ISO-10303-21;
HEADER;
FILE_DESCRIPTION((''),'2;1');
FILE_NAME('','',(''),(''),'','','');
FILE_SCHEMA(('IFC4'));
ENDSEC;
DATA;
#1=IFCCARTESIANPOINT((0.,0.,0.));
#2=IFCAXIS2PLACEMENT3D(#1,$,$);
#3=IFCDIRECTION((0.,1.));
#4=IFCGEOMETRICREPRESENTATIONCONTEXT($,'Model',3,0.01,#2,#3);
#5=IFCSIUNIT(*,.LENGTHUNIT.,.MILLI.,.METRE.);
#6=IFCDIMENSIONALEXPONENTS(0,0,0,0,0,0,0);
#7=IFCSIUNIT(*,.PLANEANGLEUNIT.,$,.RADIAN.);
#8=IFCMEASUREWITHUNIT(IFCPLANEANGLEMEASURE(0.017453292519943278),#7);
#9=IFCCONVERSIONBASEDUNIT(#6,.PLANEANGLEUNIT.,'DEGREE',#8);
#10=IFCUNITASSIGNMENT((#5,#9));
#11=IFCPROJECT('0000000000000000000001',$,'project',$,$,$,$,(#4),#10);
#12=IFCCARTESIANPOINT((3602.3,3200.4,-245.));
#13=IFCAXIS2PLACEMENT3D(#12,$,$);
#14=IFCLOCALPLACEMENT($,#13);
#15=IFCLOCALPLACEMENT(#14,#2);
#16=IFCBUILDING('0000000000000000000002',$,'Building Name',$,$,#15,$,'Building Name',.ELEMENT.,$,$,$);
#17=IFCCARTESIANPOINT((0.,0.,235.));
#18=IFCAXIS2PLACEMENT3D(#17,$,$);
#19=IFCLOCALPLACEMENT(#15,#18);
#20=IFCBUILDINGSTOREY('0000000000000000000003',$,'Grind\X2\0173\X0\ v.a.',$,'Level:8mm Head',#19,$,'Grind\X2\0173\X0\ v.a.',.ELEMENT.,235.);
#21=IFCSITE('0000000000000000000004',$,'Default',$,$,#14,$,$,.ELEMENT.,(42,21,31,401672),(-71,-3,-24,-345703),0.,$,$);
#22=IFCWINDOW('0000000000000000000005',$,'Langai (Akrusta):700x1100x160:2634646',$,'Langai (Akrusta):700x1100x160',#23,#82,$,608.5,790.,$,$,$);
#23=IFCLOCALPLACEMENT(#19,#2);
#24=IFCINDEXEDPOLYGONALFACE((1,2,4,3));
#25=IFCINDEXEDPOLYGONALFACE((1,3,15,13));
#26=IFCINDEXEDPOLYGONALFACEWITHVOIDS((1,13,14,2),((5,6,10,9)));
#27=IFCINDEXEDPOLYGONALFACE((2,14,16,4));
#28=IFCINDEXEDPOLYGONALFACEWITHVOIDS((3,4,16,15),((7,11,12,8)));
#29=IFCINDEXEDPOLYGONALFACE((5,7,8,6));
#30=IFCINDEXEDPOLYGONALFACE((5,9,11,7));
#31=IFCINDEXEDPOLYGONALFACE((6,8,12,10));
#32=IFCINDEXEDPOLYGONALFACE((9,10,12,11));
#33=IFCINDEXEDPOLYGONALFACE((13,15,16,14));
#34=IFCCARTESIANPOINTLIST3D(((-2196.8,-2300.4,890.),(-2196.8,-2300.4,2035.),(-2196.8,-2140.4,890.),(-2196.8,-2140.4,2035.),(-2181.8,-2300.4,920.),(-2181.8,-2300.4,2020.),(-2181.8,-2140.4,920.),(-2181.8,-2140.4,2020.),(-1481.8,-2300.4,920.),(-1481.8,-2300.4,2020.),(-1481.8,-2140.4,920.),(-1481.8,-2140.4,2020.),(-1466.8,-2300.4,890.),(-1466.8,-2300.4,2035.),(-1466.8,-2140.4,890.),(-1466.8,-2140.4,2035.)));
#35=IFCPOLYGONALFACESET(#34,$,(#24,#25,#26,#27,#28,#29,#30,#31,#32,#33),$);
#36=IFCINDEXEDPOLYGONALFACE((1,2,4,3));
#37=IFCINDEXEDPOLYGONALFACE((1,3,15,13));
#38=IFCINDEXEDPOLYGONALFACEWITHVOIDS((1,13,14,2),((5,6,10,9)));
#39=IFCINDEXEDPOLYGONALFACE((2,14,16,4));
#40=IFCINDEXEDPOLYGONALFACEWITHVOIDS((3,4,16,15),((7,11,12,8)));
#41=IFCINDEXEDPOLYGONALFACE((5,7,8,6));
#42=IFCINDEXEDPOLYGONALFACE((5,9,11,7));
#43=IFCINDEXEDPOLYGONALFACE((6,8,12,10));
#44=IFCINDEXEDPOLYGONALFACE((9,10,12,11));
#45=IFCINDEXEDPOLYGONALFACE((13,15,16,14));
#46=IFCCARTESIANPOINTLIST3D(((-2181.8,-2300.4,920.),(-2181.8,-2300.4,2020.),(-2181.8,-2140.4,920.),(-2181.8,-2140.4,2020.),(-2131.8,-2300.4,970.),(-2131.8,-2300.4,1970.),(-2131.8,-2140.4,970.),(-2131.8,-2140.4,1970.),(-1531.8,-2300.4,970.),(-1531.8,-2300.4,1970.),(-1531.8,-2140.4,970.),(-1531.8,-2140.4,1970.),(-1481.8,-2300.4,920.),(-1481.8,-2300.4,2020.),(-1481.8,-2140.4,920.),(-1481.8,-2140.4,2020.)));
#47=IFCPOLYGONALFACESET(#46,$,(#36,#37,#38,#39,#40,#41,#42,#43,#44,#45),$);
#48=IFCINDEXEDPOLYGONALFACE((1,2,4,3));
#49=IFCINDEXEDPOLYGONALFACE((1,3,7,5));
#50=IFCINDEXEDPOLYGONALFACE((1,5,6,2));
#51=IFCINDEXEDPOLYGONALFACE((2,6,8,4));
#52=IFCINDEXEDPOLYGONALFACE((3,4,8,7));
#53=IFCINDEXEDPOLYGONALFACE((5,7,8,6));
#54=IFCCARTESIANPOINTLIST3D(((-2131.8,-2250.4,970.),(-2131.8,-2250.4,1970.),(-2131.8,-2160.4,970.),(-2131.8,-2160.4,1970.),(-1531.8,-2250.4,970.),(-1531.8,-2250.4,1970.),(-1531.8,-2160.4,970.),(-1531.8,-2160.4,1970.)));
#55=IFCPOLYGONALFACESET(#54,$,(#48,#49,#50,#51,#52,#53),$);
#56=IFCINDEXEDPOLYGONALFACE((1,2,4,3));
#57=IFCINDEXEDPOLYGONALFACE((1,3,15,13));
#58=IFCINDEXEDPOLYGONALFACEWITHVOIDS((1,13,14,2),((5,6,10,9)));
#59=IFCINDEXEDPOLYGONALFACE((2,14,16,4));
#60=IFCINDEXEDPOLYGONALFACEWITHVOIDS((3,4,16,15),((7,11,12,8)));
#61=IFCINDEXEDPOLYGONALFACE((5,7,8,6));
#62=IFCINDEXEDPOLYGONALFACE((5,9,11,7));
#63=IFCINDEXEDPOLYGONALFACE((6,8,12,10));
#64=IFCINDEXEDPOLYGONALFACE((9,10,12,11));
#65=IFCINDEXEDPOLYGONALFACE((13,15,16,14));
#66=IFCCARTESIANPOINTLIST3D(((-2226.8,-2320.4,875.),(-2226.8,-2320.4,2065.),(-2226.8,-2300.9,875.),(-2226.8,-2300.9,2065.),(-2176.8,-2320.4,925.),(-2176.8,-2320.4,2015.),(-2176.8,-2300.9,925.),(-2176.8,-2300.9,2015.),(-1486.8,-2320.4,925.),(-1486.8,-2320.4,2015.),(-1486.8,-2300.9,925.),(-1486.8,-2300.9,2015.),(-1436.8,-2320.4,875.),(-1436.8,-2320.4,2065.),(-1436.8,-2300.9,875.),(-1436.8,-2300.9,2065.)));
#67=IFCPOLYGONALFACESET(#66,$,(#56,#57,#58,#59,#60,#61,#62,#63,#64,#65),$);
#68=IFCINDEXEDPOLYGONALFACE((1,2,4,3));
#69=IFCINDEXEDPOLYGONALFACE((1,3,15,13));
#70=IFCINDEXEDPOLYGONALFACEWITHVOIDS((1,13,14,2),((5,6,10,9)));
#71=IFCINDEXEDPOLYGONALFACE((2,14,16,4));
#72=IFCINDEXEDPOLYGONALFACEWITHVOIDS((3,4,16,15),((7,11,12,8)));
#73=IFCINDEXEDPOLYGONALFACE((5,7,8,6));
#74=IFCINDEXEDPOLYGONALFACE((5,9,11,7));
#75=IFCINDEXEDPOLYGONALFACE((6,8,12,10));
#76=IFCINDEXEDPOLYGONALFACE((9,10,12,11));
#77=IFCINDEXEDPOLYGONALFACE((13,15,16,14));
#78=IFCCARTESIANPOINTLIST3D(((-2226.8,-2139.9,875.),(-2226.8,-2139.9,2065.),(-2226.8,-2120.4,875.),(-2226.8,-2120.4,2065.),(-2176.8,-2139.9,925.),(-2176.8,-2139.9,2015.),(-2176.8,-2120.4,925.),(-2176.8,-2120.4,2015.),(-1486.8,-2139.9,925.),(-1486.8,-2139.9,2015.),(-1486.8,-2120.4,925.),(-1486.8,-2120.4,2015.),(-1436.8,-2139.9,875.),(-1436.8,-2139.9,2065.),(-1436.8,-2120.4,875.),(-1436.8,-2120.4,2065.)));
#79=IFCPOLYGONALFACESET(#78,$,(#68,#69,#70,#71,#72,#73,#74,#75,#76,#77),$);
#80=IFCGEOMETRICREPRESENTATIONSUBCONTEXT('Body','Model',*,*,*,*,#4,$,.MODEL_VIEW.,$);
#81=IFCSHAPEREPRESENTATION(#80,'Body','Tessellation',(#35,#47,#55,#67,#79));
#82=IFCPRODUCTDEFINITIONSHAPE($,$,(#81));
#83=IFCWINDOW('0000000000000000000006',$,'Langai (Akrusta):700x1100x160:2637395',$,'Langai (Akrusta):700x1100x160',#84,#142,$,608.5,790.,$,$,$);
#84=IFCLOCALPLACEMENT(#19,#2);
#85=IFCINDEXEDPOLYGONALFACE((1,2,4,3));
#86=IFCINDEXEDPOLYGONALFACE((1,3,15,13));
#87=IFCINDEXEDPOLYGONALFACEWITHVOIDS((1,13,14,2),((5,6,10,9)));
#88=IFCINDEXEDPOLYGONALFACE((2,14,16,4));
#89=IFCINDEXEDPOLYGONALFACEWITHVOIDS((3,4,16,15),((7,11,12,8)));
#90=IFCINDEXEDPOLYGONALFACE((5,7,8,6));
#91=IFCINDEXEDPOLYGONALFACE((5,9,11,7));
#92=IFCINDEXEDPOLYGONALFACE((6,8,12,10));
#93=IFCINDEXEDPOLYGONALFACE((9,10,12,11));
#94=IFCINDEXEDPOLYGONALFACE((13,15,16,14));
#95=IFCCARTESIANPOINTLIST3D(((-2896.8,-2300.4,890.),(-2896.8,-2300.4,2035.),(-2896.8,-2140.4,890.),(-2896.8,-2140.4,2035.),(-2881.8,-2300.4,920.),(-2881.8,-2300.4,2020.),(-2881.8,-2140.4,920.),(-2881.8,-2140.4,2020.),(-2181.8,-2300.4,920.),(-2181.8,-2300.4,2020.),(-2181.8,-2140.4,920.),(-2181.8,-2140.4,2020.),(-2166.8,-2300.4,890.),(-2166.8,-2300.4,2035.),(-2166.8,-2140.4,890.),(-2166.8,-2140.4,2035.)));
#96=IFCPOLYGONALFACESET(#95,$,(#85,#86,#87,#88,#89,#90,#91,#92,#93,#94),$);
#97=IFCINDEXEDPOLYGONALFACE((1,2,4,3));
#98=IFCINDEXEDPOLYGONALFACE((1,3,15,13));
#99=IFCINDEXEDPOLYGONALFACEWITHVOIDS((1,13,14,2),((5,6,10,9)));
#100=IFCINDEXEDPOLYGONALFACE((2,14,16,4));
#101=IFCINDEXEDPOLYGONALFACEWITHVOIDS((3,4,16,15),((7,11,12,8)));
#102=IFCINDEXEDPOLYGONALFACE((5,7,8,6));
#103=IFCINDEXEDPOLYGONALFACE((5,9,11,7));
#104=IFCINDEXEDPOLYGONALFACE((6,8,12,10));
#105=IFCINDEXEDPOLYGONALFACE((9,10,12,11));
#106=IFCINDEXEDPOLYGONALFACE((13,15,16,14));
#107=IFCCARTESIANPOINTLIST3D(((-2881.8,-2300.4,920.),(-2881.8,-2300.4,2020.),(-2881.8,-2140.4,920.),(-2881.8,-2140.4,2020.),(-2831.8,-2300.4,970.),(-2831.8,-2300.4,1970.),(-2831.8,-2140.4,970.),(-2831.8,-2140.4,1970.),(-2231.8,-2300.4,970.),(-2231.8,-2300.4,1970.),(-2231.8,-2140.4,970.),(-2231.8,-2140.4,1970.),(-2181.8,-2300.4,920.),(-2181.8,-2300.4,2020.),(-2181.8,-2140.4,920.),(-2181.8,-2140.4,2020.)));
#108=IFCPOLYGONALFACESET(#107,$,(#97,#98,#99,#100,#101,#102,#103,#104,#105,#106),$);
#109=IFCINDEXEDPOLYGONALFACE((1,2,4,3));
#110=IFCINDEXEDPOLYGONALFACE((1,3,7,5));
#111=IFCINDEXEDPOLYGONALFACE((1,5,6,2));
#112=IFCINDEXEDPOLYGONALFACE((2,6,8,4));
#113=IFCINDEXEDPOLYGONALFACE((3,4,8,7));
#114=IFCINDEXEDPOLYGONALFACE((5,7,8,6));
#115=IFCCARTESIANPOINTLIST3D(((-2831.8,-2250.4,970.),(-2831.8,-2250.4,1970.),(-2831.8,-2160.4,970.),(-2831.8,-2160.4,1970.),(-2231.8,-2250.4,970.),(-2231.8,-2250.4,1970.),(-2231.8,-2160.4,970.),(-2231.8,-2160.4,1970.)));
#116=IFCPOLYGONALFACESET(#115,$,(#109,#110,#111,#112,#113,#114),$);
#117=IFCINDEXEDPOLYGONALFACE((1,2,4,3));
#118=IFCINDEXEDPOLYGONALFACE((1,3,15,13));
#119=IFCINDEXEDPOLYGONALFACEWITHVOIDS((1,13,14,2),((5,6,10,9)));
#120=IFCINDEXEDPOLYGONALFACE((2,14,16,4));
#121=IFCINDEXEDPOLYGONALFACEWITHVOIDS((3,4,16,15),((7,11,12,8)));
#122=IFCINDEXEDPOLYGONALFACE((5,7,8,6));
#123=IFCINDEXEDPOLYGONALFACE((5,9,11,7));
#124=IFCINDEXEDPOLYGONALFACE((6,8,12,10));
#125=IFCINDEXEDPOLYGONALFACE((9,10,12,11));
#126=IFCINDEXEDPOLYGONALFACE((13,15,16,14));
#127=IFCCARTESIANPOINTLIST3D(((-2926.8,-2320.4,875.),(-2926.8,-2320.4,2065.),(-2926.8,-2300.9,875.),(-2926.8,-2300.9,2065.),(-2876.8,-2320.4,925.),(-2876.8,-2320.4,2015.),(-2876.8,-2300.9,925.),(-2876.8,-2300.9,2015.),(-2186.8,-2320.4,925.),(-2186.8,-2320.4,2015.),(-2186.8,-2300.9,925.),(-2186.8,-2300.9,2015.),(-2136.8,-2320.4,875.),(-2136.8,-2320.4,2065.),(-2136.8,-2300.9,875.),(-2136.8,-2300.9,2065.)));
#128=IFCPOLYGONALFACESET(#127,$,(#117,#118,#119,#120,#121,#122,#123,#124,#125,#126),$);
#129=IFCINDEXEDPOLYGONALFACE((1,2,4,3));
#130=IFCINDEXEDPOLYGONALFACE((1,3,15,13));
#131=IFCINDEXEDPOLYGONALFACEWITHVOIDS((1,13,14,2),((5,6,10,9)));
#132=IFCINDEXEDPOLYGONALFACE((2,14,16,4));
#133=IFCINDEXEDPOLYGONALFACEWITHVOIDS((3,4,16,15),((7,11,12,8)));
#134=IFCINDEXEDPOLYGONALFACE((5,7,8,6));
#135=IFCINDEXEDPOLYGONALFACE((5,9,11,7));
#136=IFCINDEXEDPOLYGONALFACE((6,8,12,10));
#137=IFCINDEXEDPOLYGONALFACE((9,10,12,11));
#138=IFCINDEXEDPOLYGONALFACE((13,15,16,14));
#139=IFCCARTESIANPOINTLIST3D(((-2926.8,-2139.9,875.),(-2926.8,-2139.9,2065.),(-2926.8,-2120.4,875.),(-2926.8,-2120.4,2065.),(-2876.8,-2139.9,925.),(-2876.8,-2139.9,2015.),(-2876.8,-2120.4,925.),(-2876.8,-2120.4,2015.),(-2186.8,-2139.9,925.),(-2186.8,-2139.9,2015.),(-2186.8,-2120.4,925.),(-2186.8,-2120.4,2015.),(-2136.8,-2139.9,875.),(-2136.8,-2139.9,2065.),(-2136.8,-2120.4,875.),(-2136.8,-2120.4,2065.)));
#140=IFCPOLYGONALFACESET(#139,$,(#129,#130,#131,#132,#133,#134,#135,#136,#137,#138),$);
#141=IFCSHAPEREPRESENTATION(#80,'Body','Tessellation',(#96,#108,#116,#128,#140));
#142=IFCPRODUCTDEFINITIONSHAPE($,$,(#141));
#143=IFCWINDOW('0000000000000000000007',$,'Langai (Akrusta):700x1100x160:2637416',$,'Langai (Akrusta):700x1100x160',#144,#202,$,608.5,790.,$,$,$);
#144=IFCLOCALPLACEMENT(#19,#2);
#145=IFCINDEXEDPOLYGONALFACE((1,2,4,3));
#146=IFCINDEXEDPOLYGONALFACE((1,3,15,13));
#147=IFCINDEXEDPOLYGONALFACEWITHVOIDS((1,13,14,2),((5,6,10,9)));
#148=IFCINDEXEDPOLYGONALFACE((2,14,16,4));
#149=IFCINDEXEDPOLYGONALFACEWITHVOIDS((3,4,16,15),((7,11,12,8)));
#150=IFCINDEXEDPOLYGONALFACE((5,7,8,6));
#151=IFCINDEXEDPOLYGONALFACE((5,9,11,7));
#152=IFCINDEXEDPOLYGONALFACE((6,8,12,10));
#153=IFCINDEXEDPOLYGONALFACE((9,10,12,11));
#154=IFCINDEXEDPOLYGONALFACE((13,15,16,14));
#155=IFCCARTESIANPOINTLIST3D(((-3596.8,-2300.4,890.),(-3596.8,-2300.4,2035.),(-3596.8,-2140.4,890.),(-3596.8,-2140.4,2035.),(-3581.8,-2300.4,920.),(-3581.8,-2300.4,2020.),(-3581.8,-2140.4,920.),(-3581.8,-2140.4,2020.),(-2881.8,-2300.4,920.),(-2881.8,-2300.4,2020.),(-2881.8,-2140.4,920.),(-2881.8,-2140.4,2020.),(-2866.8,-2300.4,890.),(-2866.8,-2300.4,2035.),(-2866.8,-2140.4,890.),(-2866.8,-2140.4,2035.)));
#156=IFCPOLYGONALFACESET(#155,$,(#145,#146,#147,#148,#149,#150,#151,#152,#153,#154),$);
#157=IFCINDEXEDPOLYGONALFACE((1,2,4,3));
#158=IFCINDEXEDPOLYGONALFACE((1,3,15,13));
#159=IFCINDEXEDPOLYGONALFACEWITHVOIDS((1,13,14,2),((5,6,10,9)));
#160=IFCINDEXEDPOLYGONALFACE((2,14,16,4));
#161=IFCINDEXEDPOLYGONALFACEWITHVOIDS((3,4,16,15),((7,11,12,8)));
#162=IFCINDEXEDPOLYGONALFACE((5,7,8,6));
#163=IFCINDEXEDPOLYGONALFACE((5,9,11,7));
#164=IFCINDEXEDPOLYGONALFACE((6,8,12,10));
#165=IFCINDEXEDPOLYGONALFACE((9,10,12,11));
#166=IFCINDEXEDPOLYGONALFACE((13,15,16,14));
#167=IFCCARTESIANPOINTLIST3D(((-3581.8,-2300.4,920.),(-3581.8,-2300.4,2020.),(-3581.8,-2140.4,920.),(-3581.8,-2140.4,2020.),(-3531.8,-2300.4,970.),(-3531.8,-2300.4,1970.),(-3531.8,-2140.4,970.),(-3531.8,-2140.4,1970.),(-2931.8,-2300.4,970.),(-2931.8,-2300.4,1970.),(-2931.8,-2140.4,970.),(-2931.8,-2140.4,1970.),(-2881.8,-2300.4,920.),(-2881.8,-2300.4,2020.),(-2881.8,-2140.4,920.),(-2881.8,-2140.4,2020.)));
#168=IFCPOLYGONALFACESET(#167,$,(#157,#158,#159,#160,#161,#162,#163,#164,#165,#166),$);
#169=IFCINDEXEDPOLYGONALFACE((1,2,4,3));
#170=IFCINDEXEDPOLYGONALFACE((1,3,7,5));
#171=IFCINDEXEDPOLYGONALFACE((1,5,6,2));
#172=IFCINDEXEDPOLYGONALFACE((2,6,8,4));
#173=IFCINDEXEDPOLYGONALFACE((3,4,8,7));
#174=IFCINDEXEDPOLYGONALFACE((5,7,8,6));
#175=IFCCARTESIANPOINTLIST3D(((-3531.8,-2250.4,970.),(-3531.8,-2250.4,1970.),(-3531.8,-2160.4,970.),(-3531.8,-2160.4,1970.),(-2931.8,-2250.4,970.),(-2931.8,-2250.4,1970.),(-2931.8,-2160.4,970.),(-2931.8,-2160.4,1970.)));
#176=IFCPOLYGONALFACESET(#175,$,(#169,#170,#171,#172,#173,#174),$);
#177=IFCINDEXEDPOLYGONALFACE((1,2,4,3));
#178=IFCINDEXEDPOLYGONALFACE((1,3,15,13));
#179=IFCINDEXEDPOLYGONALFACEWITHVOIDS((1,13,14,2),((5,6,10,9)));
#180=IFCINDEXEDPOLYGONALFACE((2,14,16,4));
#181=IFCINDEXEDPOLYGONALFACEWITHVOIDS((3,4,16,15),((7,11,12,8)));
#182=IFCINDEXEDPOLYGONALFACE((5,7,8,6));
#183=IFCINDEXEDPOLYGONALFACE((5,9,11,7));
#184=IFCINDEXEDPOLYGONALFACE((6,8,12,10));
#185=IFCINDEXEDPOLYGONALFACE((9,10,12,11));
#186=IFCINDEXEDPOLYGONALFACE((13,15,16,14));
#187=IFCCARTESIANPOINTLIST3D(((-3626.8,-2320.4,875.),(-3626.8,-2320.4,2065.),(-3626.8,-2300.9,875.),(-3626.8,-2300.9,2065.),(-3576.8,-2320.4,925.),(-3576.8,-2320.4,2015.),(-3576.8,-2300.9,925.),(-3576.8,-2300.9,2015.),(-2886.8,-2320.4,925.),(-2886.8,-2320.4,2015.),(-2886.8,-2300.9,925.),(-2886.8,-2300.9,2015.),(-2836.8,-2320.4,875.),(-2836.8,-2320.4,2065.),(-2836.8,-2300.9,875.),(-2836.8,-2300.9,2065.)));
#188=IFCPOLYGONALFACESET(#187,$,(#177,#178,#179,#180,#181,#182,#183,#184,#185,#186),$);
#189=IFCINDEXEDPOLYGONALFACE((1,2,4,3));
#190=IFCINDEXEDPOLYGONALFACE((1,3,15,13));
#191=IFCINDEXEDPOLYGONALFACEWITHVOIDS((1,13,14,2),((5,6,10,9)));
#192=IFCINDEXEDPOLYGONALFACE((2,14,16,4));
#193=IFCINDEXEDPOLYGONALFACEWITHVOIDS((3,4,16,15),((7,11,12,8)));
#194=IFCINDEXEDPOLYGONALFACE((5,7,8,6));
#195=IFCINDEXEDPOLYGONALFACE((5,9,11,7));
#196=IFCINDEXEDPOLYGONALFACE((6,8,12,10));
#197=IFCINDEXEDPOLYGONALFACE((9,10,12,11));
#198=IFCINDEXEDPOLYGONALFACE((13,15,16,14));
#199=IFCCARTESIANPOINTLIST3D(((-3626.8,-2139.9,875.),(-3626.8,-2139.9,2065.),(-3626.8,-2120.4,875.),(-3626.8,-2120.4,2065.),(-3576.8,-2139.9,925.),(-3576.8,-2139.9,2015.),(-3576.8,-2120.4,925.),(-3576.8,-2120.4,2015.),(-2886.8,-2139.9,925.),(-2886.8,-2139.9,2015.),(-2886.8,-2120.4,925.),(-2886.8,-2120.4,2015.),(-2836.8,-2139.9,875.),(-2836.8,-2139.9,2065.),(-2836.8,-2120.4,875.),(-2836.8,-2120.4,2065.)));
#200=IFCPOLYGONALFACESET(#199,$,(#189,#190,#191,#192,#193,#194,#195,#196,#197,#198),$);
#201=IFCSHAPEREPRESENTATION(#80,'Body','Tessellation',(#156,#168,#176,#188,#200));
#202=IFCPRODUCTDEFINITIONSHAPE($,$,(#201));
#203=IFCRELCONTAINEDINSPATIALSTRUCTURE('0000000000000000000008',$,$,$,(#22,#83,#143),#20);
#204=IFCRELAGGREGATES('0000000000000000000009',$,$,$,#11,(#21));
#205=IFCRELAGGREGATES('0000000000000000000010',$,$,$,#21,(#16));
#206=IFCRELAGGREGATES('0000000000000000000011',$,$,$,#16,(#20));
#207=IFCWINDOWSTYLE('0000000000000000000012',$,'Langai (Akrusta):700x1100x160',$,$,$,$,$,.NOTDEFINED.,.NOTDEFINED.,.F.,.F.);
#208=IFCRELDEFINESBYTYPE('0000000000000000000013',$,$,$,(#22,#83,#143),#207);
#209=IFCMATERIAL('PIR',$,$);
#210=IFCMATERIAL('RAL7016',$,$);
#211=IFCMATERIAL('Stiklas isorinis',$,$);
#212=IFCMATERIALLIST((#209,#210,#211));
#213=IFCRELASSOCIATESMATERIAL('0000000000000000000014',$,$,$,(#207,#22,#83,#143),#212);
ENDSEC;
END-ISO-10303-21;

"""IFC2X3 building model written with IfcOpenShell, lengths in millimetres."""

from ifc_helpers import new_model, entity, si_unit, converted_unit, direction, frame, frame_2d, origin, place, context, subcontext, project, spatial, polyline, rectangle, outline, extrude, source, transform, mapped, material, material_list, type_object, type_shapes, element, save


model = new_model("IFC2X3")

# Units and contexts
model_context = context("Model", 3, precision=0.01, world=origin(), true_north=direction((0.0, 1.0)))
body_context = subcontext(model_context, "Body", "Model", "MODEL_VIEW")
ifc_project = project(units=[si_unit("LENGTHUNIT", "METRE", prefix="MILLI"), converted_unit("PLANEANGLEUNIT", "DEGREE", entity("IfcPlaneAngleMeasure", 0.017453292519943278), si_unit("PLANEANGLEUNIT", "RADIAN"), dimensions=[0, 0, 0, 0, 0, 0, 0])], contexts=[model_context])

# Site, building, storey
site_placement = place(None, frame((3602.3, 3200.4, -245.0)))
site = spatial("IfcSite", under=ifc_project, at=site_placement, Name="Default", CompositionType="ELEMENT", RefLatitude=(42, 21, 31, 401672), RefLongitude=(-71, -3, -24, -345703), RefElevation=0.0)
building_placement = place(site_placement, origin())
building = spatial("IfcBuilding", under=site, at=building_placement, Name="Building Name", LongName="Building Name", CompositionType="ELEMENT")
storey_placement = place(building_placement, frame((0.0, 0.0, 235.0)))
storey = spatial("IfcBuildingStorey", under=building, at=storey_placement, Name="Grindų v.a.", ObjectType="Level:8mm Head", LongName="Grindų v.a.", CompositionType="ELEMENT", Elevation=235.0)

# Shared definitions
ifc_material_1 = material(Name="PIR")

# Shared definitions
ifc_material_2 = material(Name="RAL7016")

# Windows
ifc_material_3 = material(Name="Stiklas isorinis")
ifc_material_list_1 = material_list([ifc_material_1, ifc_material_2, ifc_material_3])
window_style = type_object("IfcWindowStyle", Name="Langai (Akrusta):700x1100x160", ConstructionType="NOTDEFINED", OperationType="NOTDEFINED", ParameterTakesPrecedence=False, Sizeable=False, material=ifc_material_list_1)
shared_shape_1 = source(origin(), body_context, "Body", "SweptSolid", [
    extrude(outline(polyline([(-572.5, -365.0), (572.5, -365.0), (572.5, 365.0), (-572.5, 365.0), (-572.5, -365.0)]), holes=[polyline([(557.5, 350.0), (557.5, -350.0), (-542.5, -350.0), (-542.5, 350.0), (557.5, 350.0)])]), frame((0.0, 0.0, 1462.5), z_axis=(0.0, 1.0, 0.0), x_axis=(0.0, 0.0, 1.0)), (0.0, 0.0, 1.0), 160.0),
    extrude(outline(polyline([(-550.0, -350.0), (550.0, -350.0), (550.0, 350.0), (-550.0, 350.0), (-550.0, -350.0)]), holes=[polyline([(-500.0, 300.0), (500.0, 300.0), (500.0, -300.0), (-500.0, -300.0), (-500.0, 300.0)])]), frame((0.0, 0.0, 1470.0), z_axis=(0.0, 1.0, 0.0), x_axis=(0.0, 0.0, 1.0)), (0.0, 0.0, 1.0), 160.0),
    extrude(rectangle(XDim=90.0, YDim=600.0, at=frame_2d((0.0, 0.0), x_axis=(1.0, 0.0))), frame((0.0, 95.0, 970.0), z_axis=(0.0, 0.0, 1.0), x_axis=(0.0, 1.0, 0.0)), (0.0, 0.0, 1.0), 1000.0),
    extrude(outline(polyline([(-395.0, -595.0), (395.0, -595.0), (395.0, 595.0), (-395.0, 595.0), (-395.0, -595.0)]), holes=[polyline([(-345.0, 545.0), (345.0, 545.0), (345.0, -545.0), (-345.0, -545.0), (-345.0, 545.0)])]), frame((0.0, -20.0, 1470.0), z_axis=(0.0, 1.0, 0.0), x_axis=(1.0, 0.0, 0.0)), (0.0, 0.0, 1.0), 19.5),
    extrude(outline(polyline([(-395.0, -595.0), (395.0, -595.0), (395.0, 595.0), (-395.0, 595.0), (-395.0, -595.0)]), holes=[polyline([(-345.0, 545.0), (345.0, 545.0), (345.0, -545.0), (-345.0, -545.0), (-345.0, 545.0)])]), frame((0.0, 160.5, 1470.0), z_axis=(0.0, 1.0, 0.0), x_axis=(1.0, 0.0, 0.0)), (0.0, 0.0, 1.0), 19.5),
])
type_shapes(window_style, [shared_shape_1])
for number, where, name in (
    (1, (-1831.8, -2300.4, 0.0), "Langai (Akrusta):700x1100x160:2634646"),
    (2, (-2531.8, -2300.4, 0.0), "Langai (Akrusta):700x1100x160:2637395"),
    (3, (-3231.8, -2300.4, 0.0), "Langai (Akrusta):700x1100x160:2637416"),
):
    element("IfcWindow", number, at=place(storey_placement, frame(where)), inside=storey, type_object=window_style, material=ifc_material_list_1, Name=name, ObjectType="Langai (Akrusta):700x1100x160", OverallHeight=608.5, OverallWidth=790.0, context=body_context, shape_type="MappedRepresentation", body=[
        mapped(shared_shape_1, transform((0.0, 0.0, 0.0), scale=1.0)),
    ])

save(model, "model.ifc")
